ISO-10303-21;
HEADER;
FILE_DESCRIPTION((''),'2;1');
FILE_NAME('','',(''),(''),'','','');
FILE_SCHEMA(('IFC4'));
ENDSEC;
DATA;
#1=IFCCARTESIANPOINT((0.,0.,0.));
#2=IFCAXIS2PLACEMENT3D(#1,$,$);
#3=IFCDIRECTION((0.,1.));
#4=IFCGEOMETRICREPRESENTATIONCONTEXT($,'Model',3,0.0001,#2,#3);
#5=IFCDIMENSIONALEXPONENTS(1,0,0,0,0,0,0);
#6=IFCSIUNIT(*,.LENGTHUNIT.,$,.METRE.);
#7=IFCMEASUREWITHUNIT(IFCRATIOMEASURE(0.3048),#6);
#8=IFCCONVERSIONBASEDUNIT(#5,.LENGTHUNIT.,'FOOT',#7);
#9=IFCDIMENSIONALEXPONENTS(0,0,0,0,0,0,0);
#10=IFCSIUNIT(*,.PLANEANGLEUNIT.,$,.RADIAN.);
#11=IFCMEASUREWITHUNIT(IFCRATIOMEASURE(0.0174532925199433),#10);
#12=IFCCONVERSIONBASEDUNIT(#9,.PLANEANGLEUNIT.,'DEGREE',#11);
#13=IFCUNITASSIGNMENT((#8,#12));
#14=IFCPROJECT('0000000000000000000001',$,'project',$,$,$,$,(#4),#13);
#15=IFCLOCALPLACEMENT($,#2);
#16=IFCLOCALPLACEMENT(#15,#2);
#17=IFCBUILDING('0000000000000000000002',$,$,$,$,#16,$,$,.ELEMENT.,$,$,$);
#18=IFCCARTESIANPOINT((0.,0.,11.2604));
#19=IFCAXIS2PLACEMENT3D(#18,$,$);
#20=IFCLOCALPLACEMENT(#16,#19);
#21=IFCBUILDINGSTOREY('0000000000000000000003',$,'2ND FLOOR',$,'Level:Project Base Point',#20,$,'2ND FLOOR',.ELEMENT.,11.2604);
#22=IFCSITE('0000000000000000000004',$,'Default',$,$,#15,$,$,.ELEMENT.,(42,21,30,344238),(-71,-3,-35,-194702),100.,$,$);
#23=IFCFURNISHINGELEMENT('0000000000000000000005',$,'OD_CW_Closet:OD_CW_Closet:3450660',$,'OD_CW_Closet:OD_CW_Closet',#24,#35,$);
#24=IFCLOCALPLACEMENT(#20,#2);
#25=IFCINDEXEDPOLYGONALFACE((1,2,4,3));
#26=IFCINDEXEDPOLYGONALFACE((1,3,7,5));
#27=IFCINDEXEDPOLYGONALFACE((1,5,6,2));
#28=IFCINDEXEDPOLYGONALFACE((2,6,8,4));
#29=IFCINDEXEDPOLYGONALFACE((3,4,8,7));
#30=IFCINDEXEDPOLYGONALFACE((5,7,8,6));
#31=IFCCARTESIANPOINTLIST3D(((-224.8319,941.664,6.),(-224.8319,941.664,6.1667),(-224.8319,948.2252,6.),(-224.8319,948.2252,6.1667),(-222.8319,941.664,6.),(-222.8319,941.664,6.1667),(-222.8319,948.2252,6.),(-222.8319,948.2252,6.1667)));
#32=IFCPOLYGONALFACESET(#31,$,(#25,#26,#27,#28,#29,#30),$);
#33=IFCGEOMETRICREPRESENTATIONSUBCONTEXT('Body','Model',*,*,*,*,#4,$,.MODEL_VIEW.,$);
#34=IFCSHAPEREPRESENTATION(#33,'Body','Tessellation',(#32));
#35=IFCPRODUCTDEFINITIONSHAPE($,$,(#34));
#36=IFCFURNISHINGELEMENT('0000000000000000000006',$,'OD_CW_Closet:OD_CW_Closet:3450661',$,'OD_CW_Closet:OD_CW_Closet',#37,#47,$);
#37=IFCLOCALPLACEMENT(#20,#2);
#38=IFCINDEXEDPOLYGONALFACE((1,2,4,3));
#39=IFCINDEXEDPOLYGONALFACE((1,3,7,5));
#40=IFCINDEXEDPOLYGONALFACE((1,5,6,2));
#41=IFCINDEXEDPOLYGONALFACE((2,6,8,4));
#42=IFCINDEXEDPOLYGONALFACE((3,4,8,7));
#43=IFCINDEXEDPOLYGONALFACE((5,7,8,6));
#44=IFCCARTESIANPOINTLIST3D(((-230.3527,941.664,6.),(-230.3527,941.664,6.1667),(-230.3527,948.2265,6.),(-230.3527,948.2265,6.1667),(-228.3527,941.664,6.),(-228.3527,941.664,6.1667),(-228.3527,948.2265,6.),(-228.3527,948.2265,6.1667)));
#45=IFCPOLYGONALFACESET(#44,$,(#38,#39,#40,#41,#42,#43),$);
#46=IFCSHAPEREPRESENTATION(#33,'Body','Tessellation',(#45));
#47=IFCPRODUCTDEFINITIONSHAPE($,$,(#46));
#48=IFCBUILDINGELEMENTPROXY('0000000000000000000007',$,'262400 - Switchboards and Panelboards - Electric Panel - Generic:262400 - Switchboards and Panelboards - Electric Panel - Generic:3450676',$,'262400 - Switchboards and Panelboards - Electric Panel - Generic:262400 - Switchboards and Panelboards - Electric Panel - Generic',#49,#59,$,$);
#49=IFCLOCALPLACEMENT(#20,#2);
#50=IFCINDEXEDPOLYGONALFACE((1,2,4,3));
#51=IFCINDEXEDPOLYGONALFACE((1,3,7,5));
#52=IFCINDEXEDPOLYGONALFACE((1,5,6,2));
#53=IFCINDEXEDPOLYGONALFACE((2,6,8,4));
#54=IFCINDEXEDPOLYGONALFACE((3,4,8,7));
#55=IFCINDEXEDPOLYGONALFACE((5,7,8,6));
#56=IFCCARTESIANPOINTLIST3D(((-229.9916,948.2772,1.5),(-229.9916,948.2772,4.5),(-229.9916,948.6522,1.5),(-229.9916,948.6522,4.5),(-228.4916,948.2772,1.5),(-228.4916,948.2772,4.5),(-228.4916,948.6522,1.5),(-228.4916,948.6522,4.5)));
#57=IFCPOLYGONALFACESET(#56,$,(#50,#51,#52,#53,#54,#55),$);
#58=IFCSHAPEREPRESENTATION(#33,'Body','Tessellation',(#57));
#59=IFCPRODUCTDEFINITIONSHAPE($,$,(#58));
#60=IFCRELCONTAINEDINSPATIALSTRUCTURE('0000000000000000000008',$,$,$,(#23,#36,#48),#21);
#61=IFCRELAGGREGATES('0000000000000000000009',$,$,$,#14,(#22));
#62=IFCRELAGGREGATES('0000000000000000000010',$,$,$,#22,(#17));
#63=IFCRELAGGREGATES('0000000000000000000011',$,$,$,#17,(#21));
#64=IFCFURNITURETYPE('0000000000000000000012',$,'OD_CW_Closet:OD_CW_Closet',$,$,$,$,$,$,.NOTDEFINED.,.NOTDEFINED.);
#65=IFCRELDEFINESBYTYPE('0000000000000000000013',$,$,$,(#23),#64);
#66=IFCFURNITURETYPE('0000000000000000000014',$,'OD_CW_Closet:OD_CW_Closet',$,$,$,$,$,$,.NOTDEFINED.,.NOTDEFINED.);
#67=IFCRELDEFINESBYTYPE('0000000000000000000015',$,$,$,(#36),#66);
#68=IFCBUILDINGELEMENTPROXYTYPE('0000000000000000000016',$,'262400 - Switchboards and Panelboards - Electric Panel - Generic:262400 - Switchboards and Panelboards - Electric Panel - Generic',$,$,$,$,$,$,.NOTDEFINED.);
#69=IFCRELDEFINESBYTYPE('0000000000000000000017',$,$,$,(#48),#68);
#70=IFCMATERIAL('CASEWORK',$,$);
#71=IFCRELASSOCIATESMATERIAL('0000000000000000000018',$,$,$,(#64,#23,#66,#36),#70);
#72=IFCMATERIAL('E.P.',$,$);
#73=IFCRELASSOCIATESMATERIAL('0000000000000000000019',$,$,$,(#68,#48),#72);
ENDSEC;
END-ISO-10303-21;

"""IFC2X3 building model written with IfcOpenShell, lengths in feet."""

from ifc_helpers import new_model, entity, si_unit, converted_unit, direction, frame, origin, origin_2d_with_axis, place, context, subcontext, project, spatial, rectangle, extrude, source, transform, mapped, material, type_object, type_shapes, element, save


model = new_model("IFC2X3")

# Units and contexts
model_context = context("Model", 3, precision=0.0001, world=origin(), true_north=direction((0.0, 1.0)))
body_context = subcontext(model_context, "Body", "Model", "MODEL_VIEW")
ifc_project = project(units=[converted_unit("LENGTHUNIT", "FOOT", entity("IfcRatioMeasure", 0.3048), si_unit("LENGTHUNIT", "METRE"), dimensions=[1, 0, 0, 0, 0, 0, 0]), converted_unit("PLANEANGLEUNIT", "DEGREE", entity("IfcRatioMeasure", 0.0174532925199433), si_unit("PLANEANGLEUNIT", "RADIAN"), dimensions=[0, 0, 0, 0, 0, 0, 0])], contexts=[model_context])

# Site, building, storey
site_placement = place(None, origin())
site = spatial("IfcSite", under=ifc_project, at=site_placement, Name="Default", CompositionType="ELEMENT", RefLatitude=(42, 21, 30, 344238), RefLongitude=(-71, -3, -35, -194702), RefElevation=100.0)
building_placement = place(site_placement, origin())
building = spatial("IfcBuilding", under=site, at=building_placement, CompositionType="ELEMENT")
storey_placement = place(building_placement, frame((0.0, 0.0, 11.2604)))
storey = spatial("IfcBuildingStorey", under=building, at=storey_placement, Name="2ND FLOOR", ObjectType="Level:Project Base Point", LongName="2ND FLOOR", CompositionType="ELEMENT", Elevation=11.2604)

# Furnishing elements
ifc_material_1 = material(Name="CASEWORK")
furniture_type_1 = type_object("IfcFurnitureType", Name="OD_CW_Closet:OD_CW_Closet", material=ifc_material_1)
shared_shape_1 = source(origin(), body_context, "Body", "SweptSolid", [
    extrude(rectangle(XDim=2.0, YDim=6.5611, at=origin_2d_with_axis()), frame((3.2806, 1.0, 0.0), z_axis=(0.0, 0.0, 1.0), x_axis=(0.0, -1.0, 0.0)), (0.0, 0.0, 1.0), 0.1667),
])
type_shapes(furniture_type_1, [shared_shape_1])
furnishing_1_placement = place(storey_placement, frame((-224.8319, 948.2252, 6.0), z_axis=(0.0, 0.0, 1.0), x_axis=(0.0, -1.0, 0.0)))
element("IfcFurnishingElement", 1, at=furnishing_1_placement, inside=storey, type_object=furniture_type_1, material=ifc_material_1, Name="OD_CW_Closet:OD_CW_Closet:3450660", ObjectType="OD_CW_Closet:OD_CW_Closet", context=body_context, shape_type="MappedRepresentation", body=[
    mapped(shared_shape_1, transform((0.0, 0.0, 0.0), scale=1.0)),
])
furniture_type_2 = type_object("IfcFurnitureType", Name="OD_CW_Closet:OD_CW_Closet", material=ifc_material_1)
shared_shape_2 = source(origin(), body_context, "Body", "SweptSolid", [
    extrude(rectangle(XDim=6.5625, YDim=2.0, at=origin_2d_with_axis()), frame((3.2813, 1.0, 0.0)), (0.0, 0.0, 1.0), 0.1667),
])
type_shapes(furniture_type_2, [shared_shape_2])
furnishing_2_placement = place(storey_placement, frame((-230.3527, 948.2265, 6.0), z_axis=(0.0, 0.0, 1.0), x_axis=(0.0, -1.0, 0.0)))
element("IfcFurnishingElement", 2, at=furnishing_2_placement, inside=storey, type_object=furniture_type_2, material=ifc_material_1, Name="OD_CW_Closet:OD_CW_Closet:3450661", ObjectType="OD_CW_Closet:OD_CW_Closet", context=body_context, shape_type="MappedRepresentation", body=[
    mapped(shared_shape_2, transform((0.0, 0.0, 0.0), scale=1.0)),
])

# Building element proxy
ifc_material_2 = material(Name="E.P.")
building_element_proxy_type_1 = type_object("IfcBuildingElementProxyType", Name="262400 - Switchboards and Panelboards - Electric Panel - Generic:262400 - Switchboards and Panelboards - Electric Panel - Generic", PredefinedType="NOTDEFINED", material=ifc_material_2)
shared_shape_3 = source(origin(), body_context, "Body", "SweptSolid", [
    extrude(rectangle(XDim=1.5, YDim=0.375, at=origin_2d_with_axis()), frame((0.75, 0.1875, 0.0), z_axis=(0.0, 0.0, 1.0), x_axis=(-1.0, 0.0, 0.0)), (0.0, 0.0, 1.0), 3.0),
])
type_shapes(building_element_proxy_type_1, [shared_shape_3])
proxy_1_placement = place(storey_placement, frame((-228.4916, 948.6522, 1.5), z_axis=(0.0, 0.0, 1.0), x_axis=(-1.0, 0.0, 0.0)))
element("IfcBuildingElementProxy", 3, at=proxy_1_placement, inside=storey, type_object=building_element_proxy_type_1, material=ifc_material_2, Name="262400 - Switchboards and Panelboards - Electric Panel - Generic:262400 - Switchboards and Panelboards - Electric Panel - Generic:3450676", ObjectType="262400 - Switchboards and Panelboards - Electric Panel - Generic:262400 - Switchboards and Panelboards - Electric Panel - Generic", context=body_context, shape_type="MappedRepresentation", body=[
    mapped(shared_shape_3, transform((0.0, 0.0, 0.0), scale=1.0)),
])

save(model, "model.ifc")
